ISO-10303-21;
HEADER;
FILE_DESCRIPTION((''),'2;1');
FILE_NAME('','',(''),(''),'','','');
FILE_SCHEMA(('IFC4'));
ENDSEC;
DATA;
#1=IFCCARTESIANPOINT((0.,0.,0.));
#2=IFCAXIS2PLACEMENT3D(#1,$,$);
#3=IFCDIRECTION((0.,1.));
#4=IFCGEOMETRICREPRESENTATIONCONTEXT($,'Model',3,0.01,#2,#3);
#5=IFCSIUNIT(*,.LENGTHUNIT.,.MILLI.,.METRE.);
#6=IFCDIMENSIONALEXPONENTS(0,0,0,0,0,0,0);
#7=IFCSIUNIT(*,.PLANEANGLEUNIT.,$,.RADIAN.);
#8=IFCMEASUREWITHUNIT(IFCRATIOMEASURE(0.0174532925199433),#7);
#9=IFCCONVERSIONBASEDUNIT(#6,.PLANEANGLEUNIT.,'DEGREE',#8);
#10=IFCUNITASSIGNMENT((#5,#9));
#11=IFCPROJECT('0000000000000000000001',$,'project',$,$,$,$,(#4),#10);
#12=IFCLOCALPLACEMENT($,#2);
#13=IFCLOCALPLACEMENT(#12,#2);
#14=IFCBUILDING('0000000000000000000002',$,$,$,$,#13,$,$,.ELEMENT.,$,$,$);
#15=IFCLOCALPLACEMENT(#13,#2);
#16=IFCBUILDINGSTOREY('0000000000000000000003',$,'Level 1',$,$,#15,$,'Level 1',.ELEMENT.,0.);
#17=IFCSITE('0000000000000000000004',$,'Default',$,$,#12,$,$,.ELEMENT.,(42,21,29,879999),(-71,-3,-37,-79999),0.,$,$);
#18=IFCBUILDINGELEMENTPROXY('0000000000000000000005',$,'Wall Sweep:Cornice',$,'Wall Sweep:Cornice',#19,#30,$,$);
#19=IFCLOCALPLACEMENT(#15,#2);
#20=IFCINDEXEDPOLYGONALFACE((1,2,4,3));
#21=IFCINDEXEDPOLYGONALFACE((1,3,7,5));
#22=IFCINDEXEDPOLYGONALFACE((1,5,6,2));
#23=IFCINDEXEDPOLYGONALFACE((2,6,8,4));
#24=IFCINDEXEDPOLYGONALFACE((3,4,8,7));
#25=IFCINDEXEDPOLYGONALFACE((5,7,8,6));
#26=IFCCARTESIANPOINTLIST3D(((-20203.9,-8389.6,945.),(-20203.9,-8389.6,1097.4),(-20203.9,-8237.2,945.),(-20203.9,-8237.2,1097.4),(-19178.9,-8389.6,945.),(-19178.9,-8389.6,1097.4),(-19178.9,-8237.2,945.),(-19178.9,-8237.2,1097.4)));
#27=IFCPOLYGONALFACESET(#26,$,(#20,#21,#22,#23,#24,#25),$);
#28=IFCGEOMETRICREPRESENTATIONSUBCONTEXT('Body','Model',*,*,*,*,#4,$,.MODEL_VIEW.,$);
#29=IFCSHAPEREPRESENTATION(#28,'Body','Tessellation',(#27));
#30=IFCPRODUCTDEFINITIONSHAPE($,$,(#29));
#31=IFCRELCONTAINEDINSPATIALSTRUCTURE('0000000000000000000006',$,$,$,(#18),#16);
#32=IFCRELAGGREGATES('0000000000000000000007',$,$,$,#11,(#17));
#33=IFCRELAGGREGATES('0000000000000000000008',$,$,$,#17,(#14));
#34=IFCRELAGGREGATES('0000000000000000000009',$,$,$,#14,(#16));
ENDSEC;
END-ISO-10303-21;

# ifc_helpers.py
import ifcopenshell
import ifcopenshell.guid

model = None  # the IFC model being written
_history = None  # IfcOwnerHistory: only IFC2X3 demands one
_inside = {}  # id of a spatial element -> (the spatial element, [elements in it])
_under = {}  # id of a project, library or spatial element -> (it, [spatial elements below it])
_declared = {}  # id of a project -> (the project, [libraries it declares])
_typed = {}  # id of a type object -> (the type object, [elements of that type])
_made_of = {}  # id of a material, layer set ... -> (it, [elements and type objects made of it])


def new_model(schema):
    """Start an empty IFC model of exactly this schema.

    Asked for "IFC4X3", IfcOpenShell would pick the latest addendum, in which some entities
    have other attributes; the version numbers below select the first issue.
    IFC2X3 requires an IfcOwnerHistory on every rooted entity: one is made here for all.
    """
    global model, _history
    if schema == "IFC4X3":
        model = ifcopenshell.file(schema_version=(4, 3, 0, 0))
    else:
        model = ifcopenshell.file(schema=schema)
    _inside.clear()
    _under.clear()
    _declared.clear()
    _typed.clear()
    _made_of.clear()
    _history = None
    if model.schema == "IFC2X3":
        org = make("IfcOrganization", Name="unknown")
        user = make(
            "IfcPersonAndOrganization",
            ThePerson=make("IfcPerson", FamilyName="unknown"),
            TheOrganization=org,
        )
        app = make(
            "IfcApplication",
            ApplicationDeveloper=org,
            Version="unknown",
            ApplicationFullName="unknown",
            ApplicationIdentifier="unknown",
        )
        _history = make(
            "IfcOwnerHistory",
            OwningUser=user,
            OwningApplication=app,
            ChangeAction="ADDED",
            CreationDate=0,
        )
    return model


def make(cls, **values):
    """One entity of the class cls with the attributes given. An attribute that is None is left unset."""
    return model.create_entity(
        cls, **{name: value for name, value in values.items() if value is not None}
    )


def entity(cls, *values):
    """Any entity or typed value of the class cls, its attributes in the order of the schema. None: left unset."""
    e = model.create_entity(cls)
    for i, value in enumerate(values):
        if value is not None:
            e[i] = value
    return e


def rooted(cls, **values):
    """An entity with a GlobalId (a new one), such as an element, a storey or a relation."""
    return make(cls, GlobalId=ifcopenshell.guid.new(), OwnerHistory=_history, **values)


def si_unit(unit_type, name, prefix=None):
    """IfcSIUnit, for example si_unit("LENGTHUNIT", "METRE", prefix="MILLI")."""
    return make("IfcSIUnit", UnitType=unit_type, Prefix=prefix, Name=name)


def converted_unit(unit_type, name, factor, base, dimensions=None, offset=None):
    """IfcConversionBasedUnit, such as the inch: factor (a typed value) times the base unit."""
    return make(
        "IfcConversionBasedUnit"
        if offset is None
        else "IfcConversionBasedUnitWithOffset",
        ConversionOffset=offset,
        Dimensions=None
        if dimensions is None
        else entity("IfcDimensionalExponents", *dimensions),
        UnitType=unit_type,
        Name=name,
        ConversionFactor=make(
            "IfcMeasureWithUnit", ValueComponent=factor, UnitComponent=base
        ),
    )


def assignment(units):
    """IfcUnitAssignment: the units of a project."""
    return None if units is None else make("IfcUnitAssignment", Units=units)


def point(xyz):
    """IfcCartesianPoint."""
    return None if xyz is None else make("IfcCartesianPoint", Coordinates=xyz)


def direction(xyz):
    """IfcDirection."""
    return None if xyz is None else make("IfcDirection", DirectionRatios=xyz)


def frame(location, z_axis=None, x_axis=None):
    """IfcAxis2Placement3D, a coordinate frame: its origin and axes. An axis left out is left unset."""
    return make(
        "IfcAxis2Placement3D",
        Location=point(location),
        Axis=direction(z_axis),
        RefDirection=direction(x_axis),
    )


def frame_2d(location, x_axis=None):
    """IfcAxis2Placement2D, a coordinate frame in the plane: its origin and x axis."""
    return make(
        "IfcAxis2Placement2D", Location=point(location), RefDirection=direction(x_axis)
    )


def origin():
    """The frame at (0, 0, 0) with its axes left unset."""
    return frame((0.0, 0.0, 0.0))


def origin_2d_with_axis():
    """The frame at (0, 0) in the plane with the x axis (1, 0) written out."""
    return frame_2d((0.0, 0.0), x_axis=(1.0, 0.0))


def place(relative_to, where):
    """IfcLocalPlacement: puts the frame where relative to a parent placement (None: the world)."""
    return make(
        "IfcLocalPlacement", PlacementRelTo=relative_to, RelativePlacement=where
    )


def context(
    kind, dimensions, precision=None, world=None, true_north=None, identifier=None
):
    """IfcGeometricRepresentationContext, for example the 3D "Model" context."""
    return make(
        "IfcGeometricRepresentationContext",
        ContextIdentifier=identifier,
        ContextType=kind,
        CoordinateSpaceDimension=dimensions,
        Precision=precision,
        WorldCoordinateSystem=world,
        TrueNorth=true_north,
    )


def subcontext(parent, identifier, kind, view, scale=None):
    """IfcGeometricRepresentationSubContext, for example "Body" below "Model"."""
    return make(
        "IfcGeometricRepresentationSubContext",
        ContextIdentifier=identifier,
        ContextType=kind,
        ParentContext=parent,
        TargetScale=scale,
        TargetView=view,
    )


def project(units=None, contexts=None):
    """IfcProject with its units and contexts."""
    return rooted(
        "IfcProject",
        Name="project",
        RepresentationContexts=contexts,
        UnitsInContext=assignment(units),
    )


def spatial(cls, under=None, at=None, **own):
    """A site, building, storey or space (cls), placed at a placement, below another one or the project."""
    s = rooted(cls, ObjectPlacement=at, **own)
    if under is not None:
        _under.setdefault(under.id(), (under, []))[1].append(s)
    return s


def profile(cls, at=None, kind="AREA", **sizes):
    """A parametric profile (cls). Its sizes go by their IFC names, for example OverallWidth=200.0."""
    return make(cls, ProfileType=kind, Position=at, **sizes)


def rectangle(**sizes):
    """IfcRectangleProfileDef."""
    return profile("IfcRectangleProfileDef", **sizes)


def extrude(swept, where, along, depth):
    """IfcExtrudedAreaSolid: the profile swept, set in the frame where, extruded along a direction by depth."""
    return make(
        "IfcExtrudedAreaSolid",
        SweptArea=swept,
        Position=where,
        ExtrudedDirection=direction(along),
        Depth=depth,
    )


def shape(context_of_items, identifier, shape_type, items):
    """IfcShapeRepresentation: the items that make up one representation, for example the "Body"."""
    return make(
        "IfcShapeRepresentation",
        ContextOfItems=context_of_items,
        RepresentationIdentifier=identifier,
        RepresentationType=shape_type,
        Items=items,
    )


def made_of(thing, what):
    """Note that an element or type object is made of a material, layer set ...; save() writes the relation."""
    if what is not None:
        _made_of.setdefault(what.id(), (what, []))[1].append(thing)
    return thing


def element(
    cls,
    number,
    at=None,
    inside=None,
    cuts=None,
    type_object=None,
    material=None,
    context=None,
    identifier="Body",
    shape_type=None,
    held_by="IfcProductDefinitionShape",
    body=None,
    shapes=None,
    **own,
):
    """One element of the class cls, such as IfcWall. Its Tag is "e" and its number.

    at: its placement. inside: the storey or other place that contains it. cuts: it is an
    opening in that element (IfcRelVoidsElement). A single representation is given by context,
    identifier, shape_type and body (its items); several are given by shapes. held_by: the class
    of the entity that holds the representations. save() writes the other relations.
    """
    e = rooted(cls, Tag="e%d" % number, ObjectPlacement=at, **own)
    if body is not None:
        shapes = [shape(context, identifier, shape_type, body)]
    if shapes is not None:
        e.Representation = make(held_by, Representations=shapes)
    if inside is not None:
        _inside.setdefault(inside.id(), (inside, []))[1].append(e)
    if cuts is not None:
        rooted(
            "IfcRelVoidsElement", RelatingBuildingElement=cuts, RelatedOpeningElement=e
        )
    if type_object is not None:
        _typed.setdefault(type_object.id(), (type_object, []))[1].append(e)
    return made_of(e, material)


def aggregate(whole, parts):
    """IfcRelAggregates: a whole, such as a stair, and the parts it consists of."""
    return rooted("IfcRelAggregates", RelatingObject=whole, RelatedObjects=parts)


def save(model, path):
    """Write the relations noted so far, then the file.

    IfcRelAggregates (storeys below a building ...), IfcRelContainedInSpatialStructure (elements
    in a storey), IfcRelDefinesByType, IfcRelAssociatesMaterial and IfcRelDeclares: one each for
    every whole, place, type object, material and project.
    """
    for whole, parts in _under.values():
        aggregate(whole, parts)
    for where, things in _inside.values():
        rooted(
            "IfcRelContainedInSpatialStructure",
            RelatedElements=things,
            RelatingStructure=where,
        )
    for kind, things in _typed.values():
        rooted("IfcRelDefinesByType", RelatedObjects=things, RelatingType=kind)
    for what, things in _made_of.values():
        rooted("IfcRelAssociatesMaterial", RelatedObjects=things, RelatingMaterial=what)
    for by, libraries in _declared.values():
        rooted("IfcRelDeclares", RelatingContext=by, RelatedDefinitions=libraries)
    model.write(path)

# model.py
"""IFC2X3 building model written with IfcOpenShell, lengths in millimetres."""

from ifc_helpers import new_model, entity, si_unit, converted_unit, direction, frame, origin, origin_2d_with_axis, place, context, subcontext, project, spatial, rectangle, extrude, element, save


model = new_model("IFC2X3")

# Units and contexts
model_context = context("Model", 3, precision=0.01, world=origin(), true_north=direction((0.0, 1.0)))
body_context = subcontext(model_context, "Body", "Model", "MODEL_VIEW")
ifc_project = project(units=[si_unit("LENGTHUNIT", "METRE", prefix="MILLI"), converted_unit("PLANEANGLEUNIT", "DEGREE", entity("IfcRatioMeasure", 0.0174532925199433), si_unit("PLANEANGLEUNIT", "RADIAN"), dimensions=[0, 0, 0, 0, 0, 0, 0])], contexts=[model_context])

# Site, building, storey
site_placement = place(None, origin())
site = spatial("IfcSite", under=ifc_project, at=site_placement, Name="Default", CompositionType="ELEMENT", RefLatitude=(42, 21, 29, 879999), RefLongitude=(-71, -3, -37, -79999), RefElevation=0.0)
building_placement = place(site_placement, origin())
building = spatial("IfcBuilding", under=site, at=building_placement, CompositionType="ELEMENT")
storey_placement = place(building_placement, origin())
storey = spatial("IfcBuildingStorey", under=building, at=storey_placement, Name="Level 1", LongName="Level 1", CompositionType="ELEMENT", Elevation=0.0)

# Building element proxy
proxy_1_placement = place(storey_placement, origin())
element("IfcBuildingElementProxy", 1, at=proxy_1_placement, inside=storey, Name="Wall Sweep:Cornice", ObjectType="Wall Sweep:Cornice", context=body_context, shape_type="SweptSolid", body=[
    extrude(rectangle(XDim=1025.0, YDim=152.4, at=origin_2d_with_axis()), frame((-19691.4, -8313.4, 945.0), z_axis=(0.0, 0.0, 1.0), x_axis=(-1.0, 0.0, 0.0)), (0.0, 0.0, 1.0), 152.4),
])

save(model, "model.ifc")
